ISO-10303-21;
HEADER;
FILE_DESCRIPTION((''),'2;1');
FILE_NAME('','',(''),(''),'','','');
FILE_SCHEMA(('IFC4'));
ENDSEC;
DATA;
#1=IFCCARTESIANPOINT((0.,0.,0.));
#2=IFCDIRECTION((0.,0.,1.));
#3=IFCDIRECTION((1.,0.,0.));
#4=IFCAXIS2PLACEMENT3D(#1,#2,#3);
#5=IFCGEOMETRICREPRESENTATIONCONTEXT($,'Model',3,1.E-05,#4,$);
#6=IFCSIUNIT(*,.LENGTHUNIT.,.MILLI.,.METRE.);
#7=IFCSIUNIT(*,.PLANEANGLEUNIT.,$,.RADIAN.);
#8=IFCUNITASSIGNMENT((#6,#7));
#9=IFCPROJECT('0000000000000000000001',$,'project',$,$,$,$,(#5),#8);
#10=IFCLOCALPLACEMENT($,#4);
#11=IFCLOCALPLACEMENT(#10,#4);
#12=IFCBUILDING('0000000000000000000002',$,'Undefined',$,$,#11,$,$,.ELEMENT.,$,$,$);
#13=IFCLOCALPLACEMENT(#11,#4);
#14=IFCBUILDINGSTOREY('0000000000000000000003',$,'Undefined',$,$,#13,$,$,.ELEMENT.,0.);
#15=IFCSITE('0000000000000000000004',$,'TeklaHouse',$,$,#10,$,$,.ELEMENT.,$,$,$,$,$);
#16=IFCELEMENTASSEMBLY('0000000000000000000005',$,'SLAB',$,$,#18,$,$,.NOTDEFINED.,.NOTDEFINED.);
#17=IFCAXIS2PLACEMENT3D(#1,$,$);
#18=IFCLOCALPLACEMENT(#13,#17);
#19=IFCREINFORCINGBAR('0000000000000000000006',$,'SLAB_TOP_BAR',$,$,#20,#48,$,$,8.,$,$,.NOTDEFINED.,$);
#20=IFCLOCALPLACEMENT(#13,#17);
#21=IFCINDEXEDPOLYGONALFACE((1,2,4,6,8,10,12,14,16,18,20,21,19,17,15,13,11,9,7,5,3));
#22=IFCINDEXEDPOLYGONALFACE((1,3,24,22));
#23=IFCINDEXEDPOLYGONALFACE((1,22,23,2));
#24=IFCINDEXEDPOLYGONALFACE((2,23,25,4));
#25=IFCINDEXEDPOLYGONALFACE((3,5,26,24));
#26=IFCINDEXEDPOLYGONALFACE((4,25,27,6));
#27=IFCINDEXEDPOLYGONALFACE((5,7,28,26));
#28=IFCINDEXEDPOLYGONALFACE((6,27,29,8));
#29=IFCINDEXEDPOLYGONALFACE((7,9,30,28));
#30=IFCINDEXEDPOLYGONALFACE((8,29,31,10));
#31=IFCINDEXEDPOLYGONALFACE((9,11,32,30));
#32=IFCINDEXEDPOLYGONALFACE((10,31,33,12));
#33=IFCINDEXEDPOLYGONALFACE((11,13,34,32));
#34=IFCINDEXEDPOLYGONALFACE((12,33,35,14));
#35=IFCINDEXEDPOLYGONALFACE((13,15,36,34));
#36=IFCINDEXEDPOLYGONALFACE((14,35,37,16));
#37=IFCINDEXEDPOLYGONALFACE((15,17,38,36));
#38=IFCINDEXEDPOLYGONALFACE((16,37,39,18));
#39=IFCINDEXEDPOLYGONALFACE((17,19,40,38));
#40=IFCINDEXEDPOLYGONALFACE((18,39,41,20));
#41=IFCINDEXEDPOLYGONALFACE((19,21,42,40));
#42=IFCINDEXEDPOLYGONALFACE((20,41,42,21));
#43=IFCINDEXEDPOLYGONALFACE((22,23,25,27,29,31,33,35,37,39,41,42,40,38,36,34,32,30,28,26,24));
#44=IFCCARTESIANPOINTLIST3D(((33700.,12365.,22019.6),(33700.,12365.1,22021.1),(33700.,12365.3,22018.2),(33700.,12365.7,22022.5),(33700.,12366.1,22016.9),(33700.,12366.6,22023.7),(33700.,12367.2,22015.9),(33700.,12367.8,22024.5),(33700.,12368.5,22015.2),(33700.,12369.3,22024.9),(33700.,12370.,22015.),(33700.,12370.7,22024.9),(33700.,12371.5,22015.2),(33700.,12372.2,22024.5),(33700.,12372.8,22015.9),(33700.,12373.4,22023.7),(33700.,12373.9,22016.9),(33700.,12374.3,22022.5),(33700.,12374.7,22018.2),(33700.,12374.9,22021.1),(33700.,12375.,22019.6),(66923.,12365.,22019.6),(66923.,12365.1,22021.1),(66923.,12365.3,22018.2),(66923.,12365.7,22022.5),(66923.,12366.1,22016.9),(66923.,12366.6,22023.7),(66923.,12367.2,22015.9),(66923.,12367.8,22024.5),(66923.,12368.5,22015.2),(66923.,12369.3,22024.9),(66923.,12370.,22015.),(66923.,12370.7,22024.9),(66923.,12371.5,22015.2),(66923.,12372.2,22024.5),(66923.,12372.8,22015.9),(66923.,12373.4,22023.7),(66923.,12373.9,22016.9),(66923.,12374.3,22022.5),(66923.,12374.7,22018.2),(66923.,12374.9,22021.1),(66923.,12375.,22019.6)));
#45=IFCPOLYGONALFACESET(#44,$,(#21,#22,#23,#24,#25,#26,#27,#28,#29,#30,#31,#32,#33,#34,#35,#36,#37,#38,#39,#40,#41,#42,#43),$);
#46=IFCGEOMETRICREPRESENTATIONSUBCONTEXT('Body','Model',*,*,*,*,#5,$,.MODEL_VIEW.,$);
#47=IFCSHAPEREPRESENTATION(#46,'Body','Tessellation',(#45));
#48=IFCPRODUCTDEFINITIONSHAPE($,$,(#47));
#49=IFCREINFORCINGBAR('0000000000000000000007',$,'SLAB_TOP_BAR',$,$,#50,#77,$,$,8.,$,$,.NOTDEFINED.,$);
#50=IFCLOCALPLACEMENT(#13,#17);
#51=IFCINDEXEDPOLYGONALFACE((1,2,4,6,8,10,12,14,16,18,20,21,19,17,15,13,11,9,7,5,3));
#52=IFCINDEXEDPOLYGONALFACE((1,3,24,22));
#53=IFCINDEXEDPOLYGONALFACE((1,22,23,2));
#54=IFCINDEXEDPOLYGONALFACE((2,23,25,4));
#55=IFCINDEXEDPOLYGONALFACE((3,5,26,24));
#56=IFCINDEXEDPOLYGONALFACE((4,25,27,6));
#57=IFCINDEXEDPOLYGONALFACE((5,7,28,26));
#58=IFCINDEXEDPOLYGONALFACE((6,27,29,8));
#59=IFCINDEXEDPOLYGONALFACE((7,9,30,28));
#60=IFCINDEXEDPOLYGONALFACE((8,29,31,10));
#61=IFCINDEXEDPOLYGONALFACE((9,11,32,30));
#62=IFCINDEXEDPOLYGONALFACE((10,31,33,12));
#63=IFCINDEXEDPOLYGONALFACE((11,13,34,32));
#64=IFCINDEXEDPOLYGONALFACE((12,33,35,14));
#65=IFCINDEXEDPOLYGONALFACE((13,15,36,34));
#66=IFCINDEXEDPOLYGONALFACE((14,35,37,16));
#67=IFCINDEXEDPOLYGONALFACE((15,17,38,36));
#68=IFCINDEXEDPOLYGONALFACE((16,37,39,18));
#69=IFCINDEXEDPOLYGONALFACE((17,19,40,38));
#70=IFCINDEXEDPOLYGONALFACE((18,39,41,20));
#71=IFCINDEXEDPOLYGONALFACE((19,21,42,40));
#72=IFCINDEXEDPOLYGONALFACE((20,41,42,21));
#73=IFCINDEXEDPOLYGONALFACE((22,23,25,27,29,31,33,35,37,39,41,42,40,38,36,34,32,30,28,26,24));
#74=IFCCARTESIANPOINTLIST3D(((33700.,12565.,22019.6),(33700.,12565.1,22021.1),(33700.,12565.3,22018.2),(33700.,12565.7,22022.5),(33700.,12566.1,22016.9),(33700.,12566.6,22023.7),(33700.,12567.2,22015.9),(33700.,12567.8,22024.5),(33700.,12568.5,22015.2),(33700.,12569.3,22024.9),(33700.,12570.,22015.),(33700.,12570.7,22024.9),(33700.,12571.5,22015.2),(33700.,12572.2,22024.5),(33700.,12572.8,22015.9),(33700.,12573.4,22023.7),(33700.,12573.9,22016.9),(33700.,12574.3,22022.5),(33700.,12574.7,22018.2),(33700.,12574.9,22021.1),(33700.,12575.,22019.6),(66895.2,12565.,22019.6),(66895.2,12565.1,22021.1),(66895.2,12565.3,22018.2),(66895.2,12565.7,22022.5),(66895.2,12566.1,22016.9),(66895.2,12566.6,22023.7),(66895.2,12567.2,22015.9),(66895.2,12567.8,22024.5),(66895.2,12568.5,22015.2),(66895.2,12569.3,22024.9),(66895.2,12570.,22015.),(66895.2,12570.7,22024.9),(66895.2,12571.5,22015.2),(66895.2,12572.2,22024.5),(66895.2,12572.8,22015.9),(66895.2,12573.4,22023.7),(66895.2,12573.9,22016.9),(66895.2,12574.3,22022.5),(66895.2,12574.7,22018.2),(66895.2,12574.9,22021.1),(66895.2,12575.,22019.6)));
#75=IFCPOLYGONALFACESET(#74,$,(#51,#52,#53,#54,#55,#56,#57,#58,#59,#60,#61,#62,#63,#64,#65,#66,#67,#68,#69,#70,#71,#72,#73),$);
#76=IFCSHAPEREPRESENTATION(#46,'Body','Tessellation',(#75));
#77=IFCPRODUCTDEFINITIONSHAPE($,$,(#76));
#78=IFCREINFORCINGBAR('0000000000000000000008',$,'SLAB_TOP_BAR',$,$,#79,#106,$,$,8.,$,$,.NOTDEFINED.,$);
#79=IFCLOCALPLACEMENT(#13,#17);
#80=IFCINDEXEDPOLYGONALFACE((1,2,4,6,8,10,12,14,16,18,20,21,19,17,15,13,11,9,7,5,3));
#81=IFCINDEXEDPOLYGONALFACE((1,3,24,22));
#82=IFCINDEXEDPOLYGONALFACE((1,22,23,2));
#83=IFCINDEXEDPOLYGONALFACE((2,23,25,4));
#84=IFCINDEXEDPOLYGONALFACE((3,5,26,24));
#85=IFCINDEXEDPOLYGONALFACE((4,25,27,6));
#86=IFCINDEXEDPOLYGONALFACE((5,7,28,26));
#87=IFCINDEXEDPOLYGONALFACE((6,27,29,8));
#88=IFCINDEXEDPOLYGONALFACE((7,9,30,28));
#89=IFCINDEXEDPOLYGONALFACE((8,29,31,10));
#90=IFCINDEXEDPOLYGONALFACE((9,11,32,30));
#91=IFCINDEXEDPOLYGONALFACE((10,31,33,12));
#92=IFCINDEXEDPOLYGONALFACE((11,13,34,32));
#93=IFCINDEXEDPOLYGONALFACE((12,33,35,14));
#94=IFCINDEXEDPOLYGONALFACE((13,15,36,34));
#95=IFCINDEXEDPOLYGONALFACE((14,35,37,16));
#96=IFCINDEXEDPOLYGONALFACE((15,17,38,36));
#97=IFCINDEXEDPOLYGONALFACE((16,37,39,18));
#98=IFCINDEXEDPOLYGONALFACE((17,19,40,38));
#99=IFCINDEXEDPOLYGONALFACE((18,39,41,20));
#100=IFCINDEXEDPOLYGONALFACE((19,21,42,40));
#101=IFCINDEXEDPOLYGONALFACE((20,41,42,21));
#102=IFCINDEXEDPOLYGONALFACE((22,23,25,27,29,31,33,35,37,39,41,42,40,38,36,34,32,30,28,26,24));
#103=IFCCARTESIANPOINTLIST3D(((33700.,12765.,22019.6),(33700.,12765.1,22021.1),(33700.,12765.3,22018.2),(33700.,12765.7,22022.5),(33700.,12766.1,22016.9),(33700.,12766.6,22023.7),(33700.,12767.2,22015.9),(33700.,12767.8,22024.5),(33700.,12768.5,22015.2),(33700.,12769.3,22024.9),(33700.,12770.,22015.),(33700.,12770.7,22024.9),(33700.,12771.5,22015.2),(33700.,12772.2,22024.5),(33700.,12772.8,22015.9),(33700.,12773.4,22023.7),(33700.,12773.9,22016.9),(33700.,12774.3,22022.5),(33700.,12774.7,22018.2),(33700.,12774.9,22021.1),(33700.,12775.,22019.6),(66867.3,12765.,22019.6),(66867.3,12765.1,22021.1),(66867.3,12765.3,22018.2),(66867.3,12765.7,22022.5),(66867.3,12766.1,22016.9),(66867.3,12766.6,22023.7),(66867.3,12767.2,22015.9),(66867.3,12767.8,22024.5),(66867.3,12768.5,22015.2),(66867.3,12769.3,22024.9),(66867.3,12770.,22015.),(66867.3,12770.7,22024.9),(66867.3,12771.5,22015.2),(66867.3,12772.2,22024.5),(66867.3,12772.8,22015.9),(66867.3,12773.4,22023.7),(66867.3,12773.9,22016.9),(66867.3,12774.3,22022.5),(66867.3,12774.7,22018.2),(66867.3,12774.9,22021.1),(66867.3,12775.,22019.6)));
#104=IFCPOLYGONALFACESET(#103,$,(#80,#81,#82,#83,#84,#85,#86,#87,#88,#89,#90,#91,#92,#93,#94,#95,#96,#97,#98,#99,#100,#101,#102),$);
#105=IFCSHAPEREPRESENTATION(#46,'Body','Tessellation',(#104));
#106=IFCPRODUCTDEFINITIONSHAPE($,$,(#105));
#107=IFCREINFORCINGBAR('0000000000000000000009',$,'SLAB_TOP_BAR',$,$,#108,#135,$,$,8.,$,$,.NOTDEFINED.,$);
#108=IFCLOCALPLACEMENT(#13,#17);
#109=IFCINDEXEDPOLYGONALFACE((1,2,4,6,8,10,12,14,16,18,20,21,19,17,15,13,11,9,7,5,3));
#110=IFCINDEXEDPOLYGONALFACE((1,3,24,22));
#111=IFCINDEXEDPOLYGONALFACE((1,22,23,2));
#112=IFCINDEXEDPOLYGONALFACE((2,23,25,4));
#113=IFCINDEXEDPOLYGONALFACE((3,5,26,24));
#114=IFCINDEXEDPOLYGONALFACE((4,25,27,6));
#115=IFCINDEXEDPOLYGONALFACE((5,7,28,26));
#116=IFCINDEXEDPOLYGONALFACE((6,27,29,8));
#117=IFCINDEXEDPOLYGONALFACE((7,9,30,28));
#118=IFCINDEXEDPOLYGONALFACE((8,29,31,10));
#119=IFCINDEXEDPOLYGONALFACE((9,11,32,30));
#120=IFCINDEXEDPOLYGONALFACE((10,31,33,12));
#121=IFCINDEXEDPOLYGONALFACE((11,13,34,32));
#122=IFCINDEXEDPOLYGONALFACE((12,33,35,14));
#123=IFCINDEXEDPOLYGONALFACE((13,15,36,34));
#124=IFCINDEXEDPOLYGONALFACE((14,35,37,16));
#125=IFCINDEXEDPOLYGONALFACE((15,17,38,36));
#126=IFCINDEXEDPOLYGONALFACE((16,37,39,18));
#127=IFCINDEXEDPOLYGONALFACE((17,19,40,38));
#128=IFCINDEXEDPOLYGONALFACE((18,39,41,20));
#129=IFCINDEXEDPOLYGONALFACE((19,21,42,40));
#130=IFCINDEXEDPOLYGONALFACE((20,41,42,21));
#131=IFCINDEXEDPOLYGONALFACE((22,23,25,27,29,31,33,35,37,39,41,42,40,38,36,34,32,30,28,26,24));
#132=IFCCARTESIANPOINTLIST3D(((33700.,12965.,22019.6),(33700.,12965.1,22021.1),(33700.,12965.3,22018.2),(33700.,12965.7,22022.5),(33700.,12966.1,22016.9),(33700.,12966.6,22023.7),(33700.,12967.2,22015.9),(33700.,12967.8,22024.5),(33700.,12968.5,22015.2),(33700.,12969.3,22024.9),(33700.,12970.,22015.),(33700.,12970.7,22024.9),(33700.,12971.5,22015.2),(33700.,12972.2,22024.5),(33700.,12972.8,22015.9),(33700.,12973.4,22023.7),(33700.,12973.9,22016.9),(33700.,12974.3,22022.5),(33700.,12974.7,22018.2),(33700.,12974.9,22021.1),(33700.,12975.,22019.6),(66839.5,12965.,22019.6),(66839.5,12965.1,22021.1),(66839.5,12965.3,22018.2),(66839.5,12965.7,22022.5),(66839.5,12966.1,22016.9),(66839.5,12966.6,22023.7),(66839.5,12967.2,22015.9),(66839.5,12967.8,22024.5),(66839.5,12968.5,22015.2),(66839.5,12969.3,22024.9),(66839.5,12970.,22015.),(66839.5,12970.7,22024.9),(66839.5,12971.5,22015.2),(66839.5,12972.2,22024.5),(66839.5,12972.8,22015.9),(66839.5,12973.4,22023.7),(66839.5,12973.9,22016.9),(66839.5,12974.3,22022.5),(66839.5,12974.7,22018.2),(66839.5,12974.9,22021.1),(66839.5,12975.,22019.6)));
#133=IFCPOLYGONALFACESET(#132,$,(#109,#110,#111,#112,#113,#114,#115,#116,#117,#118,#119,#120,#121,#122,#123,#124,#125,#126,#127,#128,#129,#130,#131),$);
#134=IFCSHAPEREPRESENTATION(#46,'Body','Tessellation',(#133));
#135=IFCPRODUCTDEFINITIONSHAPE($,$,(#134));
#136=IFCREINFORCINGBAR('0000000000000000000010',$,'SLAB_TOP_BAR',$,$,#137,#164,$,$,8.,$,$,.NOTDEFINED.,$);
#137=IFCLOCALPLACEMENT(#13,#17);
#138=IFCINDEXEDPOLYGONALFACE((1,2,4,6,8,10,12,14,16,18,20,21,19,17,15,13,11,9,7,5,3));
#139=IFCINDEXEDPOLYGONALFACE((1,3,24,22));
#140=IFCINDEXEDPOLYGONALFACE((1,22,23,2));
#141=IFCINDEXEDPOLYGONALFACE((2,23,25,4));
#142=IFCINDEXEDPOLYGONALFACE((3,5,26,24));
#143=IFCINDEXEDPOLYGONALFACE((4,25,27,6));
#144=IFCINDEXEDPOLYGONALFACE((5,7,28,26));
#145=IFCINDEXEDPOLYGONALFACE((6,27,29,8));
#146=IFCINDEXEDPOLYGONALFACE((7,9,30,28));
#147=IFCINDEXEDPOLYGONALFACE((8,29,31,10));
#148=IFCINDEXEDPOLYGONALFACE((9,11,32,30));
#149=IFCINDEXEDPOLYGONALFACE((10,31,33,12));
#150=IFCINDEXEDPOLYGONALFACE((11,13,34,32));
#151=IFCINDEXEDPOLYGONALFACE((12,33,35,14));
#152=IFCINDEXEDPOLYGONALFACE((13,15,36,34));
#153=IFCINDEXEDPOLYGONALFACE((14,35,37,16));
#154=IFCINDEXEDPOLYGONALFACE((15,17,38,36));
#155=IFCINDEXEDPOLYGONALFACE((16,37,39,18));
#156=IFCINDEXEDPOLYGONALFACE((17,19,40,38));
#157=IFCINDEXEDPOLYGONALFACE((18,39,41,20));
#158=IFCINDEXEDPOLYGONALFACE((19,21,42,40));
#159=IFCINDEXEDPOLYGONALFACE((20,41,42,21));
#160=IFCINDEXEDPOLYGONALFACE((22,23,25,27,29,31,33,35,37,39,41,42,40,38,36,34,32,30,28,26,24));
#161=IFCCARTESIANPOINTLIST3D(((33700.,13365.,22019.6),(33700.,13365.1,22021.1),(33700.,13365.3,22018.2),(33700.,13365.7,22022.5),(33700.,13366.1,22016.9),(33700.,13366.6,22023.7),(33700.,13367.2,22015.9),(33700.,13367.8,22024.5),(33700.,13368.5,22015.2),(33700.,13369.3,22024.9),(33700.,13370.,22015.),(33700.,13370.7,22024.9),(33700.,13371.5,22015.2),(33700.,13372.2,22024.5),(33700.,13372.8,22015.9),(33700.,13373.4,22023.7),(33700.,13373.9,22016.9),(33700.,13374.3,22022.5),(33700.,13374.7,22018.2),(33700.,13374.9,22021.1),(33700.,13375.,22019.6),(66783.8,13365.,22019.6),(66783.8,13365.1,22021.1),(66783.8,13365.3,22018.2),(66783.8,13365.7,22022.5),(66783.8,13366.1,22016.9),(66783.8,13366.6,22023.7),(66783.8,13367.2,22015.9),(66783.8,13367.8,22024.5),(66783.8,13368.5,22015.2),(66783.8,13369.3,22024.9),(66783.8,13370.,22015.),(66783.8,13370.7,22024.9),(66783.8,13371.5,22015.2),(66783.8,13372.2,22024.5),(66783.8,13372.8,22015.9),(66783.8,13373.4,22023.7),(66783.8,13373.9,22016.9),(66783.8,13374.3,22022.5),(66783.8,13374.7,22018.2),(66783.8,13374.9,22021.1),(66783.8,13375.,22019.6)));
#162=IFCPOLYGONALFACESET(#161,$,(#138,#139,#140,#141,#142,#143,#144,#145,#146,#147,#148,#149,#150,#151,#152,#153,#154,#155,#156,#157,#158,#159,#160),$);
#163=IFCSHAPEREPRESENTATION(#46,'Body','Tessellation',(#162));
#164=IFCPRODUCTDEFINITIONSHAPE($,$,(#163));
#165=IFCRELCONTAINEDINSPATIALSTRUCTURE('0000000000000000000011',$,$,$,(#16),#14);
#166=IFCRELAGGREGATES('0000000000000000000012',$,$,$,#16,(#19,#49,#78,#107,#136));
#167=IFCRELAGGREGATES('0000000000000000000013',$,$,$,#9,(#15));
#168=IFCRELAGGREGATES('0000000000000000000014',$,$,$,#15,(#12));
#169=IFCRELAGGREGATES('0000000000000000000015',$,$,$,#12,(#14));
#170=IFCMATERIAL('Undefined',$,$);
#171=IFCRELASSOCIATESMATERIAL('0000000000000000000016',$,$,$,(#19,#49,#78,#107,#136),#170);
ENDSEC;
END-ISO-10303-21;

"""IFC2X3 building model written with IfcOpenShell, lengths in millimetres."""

from ifc_helpers import new_model, entity, si_unit, frame, origin_with_axes, place, context, subcontext, project, spatial, source, transform, mapped, material, element, aggregate, save


model = new_model("IFC2X3")

# Units and contexts
model_context = context("Model", 3, precision=1e-05, world=origin_with_axes())
body_context = subcontext(model_context, "Body", "Model", "MODEL_VIEW")
ifc_project = project(units=[si_unit("LENGTHUNIT", "METRE", prefix="MILLI"), si_unit("PLANEANGLEUNIT", "RADIAN")], contexts=[model_context])

# Site, building, storey
site_placement = place(None, origin_with_axes())
site = spatial("IfcSite", under=ifc_project, at=site_placement, Name="TeklaHouse", CompositionType="ELEMENT")
building_placement = place(site_placement, origin_with_axes())
building = spatial("IfcBuilding", under=site, at=building_placement, Name="Undefined", CompositionType="ELEMENT")
storey_placement = place(building_placement, origin_with_axes())
storey = spatial("IfcBuildingStorey", under=building, at=storey_placement, Name="Undefined", CompositionType="ELEMENT", Elevation=0.0)

# Shared definitions
ifc_material_1 = material(Name="Undefined")

# Element assembly, reinforcing bars
assembly_1_placement = place(storey_placement, origin_with_axes())
assembly_1 = element("IfcElementAssembly", 1, at=assembly_1_placement, inside=storey, Name="SLAB", AssemblyPlace="NOTDEFINED", PredefinedType="NOTDEFINED")
shared_shape_1 = source(origin_with_axes(), body_context, "Body", "AdvancedSweptSolid", [
    entity("IfcSweptDiskSolid", entity("IfcTrimmedCurve", entity("IfcLine", entity("IfcCartesianPoint", [0.0, 0.0, 0.0]), entity("IfcVector", entity("IfcDirection", [1.0, 0.0, 0.0]), 1.0)), [entity("IfcParameterValue", 0.0)], [entity("IfcParameterValue", 33223.032355)], True, "PARAMETER"), 5.0, None, 0.0, 33223.0),
])
reinforcing_bar_1_placement = place(assembly_1_placement, frame((66923.0, 12370.0, 22020.0), z_axis=(0.0, 0.0, -1.0), x_axis=(-1.0, 0.0, 0.0)))
reinforcing_bar_1 = element("IfcReinforcingBar", 2, at=reinforcing_bar_1_placement, material=ifc_material_1, Name="SLAB_TOP_BAR", BarRole="NOTDEFINED", NominalDiameter=8.0, context=body_context, shape_type="MappedRepresentation", body=[
    mapped(shared_shape_1, transform((0.0, 0.0, 0.0))),
])
shared_shape_2 = source(origin_with_axes(), body_context, "Body", "AdvancedSweptSolid", [
    entity("IfcSweptDiskSolid", entity("IfcTrimmedCurve", entity("IfcLine", entity("IfcCartesianPoint", [0.0, 0.0, 0.0]), entity("IfcVector", entity("IfcDirection", [1.0, 0.0, 0.0]), 1.0)), [entity("IfcParameterValue", 0.0)], [entity("IfcParameterValue", 33195.185891)], True, "PARAMETER"), 5.0, None, 0.0, 33195.2),
])
reinforcing_bar_2_placement = place(assembly_1_placement, frame((66895.2, 12570.0, 22020.0), z_axis=(0.0, 0.0, -1.0), x_axis=(-1.0, 0.0, 0.0)))
reinforcing_bar_2 = element("IfcReinforcingBar", 3, at=reinforcing_bar_2_placement, material=ifc_material_1, Name="SLAB_TOP_BAR", BarRole="NOTDEFINED", NominalDiameter=8.0, context=body_context, shape_type="MappedRepresentation", body=[
    mapped(shared_shape_2, transform((0.0, 0.0, 0.0))),
])
shared_shape_3 = source(origin_with_axes(), body_context, "Body", "AdvancedSweptSolid", [
    entity("IfcSweptDiskSolid", entity("IfcTrimmedCurve", entity("IfcLine", entity("IfcCartesianPoint", [0.0, 0.0, 0.0]), entity("IfcVector", entity("IfcDirection", [1.0, 0.0, 0.0]), 1.0)), [entity("IfcParameterValue", 0.0)], [entity("IfcParameterValue", 33167.339428)], True, "PARAMETER"), 5.0, None, 0.0, 33167.3),
])
reinforcing_bar_3_placement = place(assembly_1_placement, frame((66867.3, 12770.0, 22020.0), z_axis=(0.0, 0.0, -1.0), x_axis=(-1.0, 0.0, 0.0)))
reinforcing_bar_3 = element("IfcReinforcingBar", 4, at=reinforcing_bar_3_placement, material=ifc_material_1, Name="SLAB_TOP_BAR", BarRole="NOTDEFINED", NominalDiameter=8.0, context=body_context, shape_type="MappedRepresentation", body=[
    mapped(shared_shape_3, transform((0.0, 0.0, 0.0))),
])
shared_shape_4 = source(origin_with_axes(), body_context, "Body", "AdvancedSweptSolid", [
    entity("IfcSweptDiskSolid", entity("IfcTrimmedCurve", entity("IfcLine", entity("IfcCartesianPoint", [0.0, 0.0, 0.0]), entity("IfcVector", entity("IfcDirection", [1.0, 0.0, 0.0]), 1.0)), [entity("IfcParameterValue", 0.0)], [entity("IfcParameterValue", 33139.492965)], True, "PARAMETER"), 5.0, None, 0.0, 33139.5),
])
reinforcing_bar_4_placement = place(assembly_1_placement, frame((66839.5, 12970.0, 22020.0), z_axis=(0.0, 0.0, -1.0), x_axis=(-1.0, 0.0, 0.0)))
reinforcing_bar_4 = element("IfcReinforcingBar", 5, at=reinforcing_bar_4_placement, material=ifc_material_1, Name="SLAB_TOP_BAR", BarRole="NOTDEFINED", NominalDiameter=8.0, context=body_context, shape_type="MappedRepresentation", body=[
    mapped(shared_shape_4, transform((0.0, 0.0, 0.0))),
])
shared_shape_5 = source(origin_with_axes(), body_context, "Body", "AdvancedSweptSolid", [
    entity("IfcSweptDiskSolid", entity("IfcTrimmedCurve", entity("IfcLine", entity("IfcCartesianPoint", [0.0, 0.0, 0.0]), entity("IfcVector", entity("IfcDirection", [1.0, 0.0, 0.0]), 1.0)), [entity("IfcParameterValue", 0.0)], [entity("IfcParameterValue", 33083.800038)], True, "PARAMETER"), 5.0, None, 0.0, 33083.8),
])
reinforcing_bar_5_placement = place(assembly_1_placement, frame((66783.8, 13370.0, 22020.0), z_axis=(0.0, 0.0, -1.0), x_axis=(-1.0, 0.0, 0.0)))
reinforcing_bar_5 = element("IfcReinforcingBar", 6, at=reinforcing_bar_5_placement, material=ifc_material_1, Name="SLAB_TOP_BAR", BarRole="NOTDEFINED", NominalDiameter=8.0, context=body_context, shape_type="MappedRepresentation", body=[
    mapped(shared_shape_5, transform((0.0, 0.0, 0.0))),
])
aggregate(assembly_1, [reinforcing_bar_1, reinforcing_bar_2, reinforcing_bar_3, reinforcing_bar_4, reinforcing_bar_5])

save(model, "model.ifc")
